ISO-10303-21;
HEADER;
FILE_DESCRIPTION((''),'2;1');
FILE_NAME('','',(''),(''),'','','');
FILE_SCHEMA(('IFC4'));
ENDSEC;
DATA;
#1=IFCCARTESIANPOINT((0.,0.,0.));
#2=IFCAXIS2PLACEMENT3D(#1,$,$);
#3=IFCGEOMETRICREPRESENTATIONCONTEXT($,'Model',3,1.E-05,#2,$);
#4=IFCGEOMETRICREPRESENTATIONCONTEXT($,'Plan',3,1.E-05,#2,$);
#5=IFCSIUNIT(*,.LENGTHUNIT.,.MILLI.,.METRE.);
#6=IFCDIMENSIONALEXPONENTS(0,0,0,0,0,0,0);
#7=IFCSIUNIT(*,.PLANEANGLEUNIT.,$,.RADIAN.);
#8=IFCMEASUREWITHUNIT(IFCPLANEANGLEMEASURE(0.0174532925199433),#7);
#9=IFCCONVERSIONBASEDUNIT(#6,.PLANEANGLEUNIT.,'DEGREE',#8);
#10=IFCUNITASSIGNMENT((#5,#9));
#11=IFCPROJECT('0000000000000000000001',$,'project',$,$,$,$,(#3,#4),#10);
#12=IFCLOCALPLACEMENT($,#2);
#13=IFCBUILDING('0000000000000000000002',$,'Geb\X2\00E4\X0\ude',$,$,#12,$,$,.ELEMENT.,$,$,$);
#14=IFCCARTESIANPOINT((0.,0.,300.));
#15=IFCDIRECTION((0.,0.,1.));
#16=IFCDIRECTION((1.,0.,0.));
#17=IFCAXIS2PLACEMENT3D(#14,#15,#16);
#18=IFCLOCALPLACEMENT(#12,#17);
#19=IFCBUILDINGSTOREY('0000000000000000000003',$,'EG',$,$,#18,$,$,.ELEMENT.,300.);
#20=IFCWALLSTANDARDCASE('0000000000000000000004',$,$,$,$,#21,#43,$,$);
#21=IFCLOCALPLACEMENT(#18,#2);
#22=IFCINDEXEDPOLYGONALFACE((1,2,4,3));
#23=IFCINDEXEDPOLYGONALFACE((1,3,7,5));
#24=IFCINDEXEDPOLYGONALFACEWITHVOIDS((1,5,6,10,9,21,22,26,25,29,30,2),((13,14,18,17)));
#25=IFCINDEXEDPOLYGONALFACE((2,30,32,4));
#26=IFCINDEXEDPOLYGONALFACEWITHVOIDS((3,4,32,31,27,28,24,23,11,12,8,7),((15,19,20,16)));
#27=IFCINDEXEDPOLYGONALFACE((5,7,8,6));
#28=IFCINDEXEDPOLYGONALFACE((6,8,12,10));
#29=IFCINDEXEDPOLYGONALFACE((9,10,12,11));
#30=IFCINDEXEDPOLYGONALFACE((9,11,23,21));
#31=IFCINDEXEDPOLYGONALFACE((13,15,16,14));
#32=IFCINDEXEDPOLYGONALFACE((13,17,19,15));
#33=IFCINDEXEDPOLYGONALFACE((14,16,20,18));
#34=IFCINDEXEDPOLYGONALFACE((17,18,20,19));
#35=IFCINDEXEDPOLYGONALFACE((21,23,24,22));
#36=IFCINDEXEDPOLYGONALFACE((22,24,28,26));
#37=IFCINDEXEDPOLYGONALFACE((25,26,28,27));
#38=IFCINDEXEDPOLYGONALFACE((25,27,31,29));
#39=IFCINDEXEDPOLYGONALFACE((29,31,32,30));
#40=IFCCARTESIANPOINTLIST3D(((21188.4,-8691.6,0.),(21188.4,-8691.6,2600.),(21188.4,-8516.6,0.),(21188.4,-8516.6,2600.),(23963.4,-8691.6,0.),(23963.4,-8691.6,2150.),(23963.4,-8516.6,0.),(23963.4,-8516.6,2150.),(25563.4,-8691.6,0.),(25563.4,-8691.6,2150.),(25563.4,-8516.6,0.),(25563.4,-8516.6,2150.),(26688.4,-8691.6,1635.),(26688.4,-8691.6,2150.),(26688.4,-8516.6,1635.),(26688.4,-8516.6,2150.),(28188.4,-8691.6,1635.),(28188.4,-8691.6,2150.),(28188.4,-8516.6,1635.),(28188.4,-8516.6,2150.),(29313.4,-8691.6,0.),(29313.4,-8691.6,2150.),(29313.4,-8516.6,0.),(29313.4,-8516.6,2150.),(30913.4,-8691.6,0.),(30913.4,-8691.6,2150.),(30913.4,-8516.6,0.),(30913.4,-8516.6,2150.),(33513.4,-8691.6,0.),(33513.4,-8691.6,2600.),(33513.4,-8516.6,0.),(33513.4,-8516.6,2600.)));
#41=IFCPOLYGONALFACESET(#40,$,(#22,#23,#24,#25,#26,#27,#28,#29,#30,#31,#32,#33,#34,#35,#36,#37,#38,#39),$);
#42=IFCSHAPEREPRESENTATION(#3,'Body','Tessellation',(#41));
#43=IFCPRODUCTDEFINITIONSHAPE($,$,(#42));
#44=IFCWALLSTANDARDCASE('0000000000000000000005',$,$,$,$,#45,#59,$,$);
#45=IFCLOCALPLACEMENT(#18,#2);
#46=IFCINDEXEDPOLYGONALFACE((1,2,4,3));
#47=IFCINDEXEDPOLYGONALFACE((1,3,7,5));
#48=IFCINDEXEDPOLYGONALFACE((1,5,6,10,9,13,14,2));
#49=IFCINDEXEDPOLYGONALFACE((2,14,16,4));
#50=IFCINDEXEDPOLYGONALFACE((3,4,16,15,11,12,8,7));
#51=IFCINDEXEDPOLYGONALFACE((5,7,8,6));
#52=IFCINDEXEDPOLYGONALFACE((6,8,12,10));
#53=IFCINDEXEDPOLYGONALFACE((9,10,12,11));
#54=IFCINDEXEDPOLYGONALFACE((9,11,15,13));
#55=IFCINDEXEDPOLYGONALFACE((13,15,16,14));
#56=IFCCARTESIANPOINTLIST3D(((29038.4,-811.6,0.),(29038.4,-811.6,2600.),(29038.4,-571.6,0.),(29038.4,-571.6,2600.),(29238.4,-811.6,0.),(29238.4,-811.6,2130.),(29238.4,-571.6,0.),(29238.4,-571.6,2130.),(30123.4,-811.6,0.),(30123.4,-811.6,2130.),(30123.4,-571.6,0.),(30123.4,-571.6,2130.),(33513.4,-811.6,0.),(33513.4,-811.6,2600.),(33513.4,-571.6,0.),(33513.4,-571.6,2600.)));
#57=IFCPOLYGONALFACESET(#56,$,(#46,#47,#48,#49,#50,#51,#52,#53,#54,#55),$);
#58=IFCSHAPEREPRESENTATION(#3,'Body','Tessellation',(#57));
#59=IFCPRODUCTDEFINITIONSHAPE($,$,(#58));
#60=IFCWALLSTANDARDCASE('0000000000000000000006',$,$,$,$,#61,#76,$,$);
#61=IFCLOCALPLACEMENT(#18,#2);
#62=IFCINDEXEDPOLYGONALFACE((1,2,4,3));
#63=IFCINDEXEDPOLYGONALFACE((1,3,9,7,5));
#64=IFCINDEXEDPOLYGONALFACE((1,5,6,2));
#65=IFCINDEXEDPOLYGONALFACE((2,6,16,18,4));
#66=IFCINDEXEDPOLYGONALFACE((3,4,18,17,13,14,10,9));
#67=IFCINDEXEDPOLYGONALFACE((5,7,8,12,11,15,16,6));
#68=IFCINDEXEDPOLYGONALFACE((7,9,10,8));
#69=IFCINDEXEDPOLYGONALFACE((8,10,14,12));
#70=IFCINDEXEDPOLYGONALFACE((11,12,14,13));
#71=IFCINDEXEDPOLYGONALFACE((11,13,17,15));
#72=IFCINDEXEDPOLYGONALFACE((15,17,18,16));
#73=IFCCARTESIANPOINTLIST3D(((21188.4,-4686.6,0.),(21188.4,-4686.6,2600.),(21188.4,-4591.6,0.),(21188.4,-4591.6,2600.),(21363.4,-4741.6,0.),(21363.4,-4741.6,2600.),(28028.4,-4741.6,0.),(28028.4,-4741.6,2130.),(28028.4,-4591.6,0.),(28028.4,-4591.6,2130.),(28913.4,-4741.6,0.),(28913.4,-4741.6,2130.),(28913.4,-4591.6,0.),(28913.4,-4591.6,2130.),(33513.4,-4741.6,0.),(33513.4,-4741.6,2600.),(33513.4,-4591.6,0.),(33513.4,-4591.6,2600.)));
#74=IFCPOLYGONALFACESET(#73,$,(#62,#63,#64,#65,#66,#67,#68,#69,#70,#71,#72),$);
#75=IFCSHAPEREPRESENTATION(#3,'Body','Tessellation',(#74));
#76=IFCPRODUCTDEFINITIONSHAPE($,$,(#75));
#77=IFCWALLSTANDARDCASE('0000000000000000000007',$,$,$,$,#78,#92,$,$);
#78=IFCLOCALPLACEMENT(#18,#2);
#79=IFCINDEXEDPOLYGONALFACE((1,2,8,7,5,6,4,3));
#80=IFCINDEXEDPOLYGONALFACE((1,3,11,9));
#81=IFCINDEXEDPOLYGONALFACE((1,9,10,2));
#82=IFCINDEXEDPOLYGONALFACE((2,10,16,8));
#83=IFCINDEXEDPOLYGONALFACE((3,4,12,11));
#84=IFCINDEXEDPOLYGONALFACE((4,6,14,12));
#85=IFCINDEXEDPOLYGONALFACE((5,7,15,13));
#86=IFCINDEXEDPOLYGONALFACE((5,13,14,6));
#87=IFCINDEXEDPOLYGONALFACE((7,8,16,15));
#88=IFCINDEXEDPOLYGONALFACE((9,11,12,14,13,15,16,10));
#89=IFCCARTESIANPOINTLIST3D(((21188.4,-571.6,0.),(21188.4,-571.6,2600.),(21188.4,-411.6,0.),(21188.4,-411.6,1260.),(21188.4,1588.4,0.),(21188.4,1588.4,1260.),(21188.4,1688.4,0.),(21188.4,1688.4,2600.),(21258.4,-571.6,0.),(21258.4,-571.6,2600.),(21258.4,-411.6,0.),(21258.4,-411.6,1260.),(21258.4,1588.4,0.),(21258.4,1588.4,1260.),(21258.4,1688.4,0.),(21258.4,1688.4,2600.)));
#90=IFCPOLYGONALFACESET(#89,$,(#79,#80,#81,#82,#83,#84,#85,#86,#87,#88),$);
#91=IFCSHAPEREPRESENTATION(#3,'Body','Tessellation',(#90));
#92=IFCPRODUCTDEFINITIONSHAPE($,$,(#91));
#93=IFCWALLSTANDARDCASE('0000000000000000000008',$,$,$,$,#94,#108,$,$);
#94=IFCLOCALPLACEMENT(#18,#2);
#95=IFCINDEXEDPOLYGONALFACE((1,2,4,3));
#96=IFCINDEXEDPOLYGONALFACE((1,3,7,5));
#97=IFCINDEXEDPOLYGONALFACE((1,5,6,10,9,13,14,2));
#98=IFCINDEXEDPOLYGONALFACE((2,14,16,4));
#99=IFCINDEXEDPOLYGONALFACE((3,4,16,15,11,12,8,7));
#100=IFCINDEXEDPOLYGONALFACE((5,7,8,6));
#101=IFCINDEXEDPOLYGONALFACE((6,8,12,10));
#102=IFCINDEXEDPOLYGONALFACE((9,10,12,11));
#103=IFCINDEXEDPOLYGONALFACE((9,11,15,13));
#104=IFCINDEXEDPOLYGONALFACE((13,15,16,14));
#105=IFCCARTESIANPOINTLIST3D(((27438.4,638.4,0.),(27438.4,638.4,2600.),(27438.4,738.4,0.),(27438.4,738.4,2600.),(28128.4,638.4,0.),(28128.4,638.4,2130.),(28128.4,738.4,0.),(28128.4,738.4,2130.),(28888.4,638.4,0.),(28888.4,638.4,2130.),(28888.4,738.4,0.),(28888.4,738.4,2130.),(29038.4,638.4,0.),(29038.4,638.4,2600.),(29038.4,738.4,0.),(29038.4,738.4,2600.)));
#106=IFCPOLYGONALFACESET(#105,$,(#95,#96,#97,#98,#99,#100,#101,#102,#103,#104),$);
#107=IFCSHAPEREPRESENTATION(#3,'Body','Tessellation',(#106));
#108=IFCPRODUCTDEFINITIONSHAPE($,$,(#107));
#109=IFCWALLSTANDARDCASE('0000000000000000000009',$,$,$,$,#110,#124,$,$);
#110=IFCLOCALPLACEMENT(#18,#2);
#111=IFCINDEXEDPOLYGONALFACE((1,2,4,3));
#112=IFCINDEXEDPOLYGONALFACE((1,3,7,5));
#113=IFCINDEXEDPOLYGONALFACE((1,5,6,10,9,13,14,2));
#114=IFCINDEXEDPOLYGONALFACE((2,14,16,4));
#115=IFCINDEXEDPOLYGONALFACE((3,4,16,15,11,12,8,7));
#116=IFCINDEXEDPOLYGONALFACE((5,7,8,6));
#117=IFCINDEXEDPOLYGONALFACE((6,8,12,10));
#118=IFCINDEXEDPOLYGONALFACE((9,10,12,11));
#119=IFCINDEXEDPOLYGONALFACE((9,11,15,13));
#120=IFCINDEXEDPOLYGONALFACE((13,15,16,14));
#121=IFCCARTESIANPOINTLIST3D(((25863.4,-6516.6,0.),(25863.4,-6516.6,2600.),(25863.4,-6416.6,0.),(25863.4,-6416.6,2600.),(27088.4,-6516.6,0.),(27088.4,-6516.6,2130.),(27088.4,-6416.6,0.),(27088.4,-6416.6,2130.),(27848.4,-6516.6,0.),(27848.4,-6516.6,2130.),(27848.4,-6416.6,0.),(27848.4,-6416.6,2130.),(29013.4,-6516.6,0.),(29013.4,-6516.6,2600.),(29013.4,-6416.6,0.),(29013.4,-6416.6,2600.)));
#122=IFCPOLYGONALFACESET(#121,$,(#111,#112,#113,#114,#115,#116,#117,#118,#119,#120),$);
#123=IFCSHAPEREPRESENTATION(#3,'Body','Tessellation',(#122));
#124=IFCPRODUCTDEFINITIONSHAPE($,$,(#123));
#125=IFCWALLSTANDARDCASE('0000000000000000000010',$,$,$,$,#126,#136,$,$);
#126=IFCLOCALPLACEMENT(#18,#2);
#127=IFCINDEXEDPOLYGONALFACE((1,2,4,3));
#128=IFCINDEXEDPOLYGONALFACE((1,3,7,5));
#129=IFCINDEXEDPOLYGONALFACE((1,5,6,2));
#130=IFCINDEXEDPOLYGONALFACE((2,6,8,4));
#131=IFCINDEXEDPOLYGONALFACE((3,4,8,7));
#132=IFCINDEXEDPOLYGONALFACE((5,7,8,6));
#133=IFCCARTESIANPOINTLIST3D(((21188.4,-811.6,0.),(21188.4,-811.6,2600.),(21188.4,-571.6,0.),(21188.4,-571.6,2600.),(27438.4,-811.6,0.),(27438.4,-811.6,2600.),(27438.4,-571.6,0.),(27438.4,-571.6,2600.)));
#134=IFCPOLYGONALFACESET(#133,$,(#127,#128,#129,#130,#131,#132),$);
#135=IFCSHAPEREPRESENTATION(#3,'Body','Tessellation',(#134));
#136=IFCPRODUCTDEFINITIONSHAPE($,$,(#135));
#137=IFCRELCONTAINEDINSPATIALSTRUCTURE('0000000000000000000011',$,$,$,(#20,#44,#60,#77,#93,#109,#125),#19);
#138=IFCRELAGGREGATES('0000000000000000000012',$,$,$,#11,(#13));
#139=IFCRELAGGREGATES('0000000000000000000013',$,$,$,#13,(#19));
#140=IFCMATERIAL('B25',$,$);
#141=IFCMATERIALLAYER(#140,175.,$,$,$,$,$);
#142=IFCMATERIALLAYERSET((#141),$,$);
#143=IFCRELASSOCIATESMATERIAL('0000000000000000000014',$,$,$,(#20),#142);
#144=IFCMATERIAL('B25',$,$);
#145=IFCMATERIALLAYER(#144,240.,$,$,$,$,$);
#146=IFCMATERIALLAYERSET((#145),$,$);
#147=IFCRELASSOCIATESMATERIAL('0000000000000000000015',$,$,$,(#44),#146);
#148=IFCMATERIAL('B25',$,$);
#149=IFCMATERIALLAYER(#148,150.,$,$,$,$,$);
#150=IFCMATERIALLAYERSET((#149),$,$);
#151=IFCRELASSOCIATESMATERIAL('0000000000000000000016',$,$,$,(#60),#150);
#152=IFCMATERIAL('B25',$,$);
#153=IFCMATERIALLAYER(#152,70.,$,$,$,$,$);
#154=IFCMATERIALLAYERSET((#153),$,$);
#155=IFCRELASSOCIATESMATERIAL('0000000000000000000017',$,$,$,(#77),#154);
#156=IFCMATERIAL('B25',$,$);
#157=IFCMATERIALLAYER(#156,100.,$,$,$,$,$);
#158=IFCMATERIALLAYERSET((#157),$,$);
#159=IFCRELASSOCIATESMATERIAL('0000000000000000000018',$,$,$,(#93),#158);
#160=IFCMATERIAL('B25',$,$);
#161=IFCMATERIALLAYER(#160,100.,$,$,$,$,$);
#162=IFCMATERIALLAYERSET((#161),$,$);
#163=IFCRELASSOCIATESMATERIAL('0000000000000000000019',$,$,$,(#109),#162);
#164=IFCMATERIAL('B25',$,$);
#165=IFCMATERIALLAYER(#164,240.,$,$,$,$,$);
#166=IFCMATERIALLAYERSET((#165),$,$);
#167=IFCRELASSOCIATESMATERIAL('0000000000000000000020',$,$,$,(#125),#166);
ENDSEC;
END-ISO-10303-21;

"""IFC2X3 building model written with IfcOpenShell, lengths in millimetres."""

from ifc_helpers import new_model, entity, si_unit, converted_unit, frame, frame_2d, origin, origin_with_axes, place, context, project, spatial, polyline, rectangle, outline, extrude, material, layer, layer_set, layer_usage, element, save


model = new_model("IFC2X3")

# Units and contexts
model_context = context("Model", 3, precision=1e-05, world=origin())
plan_context = context("Plan", 3, precision=1e-05, world=origin())
ifc_project = project(units=[si_unit("LENGTHUNIT", "METRE", prefix="MILLI"), converted_unit("PLANEANGLEUNIT", "DEGREE", entity("IfcPlaneAngleMeasure", 0.0174532925199433), si_unit("PLANEANGLEUNIT", "RADIAN"), dimensions=[0, 0, 0, 0, 0, 0, 0])], contexts=[model_context, plan_context])

# Building, storey
building_placement = place(None, origin())
building = spatial("IfcBuilding", under=ifc_project, at=building_placement, Name="Gebäude", CompositionType="ELEMENT")
storey_placement = place(building_placement, frame((0.0, 0.0, 300.0), z_axis=(0.0, 0.0, 1.0), x_axis=(1.0, 0.0, 0.0)))
storey = spatial("IfcBuildingStorey", under=building, at=storey_placement, Name="EG", CompositionType="ELEMENT", Elevation=300.0)

# Wall, openings
ifc_material_1 = material(Name="B25")
ifc_layer_1 = layer(ifc_material_1, 175.0)
ifc_layer_set_1 = layer_set([ifc_layer_1])
ifc_layer_usage_1 = layer_usage(ifc_layer_set_1, "AXIS2", "POSITIVE", 0.0)
wall_1_placement = place(storey_placement, frame((21188.4, -8691.6, 0.0), z_axis=(0.0, 0.0, 1.0), x_axis=(1.0, 0.0, 0.0)))
wall_1 = element("IfcWallStandardCase", 1, at=wall_1_placement, inside=storey, material=ifc_layer_usage_1, context=model_context, shape_type="SweptSolid", body=[
    extrude(rectangle(XDim=12325.0, YDim=175.0, at=frame_2d((6162.5, 87.5), x_axis=(1.0, 0.0))), origin_with_axes(), (0.0, 0.0, 1.0), 2600.0),
])
opening_1_placement = place(wall_1_placement, frame((5500.0, 0.0, 1635.0), z_axis=(0.0, 1.0, 0.0), x_axis=(0.0, 0.0, 1.0)))
element("IfcOpeningElement", 2, at=opening_1_placement, cuts=wall_1, ObjectType="Opening", context=model_context, shape_type="SweptSolid", body=[
    extrude(rectangle(XDim=515.0, YDim=1500.0, at=frame_2d((257.5, 750.0), x_axis=(1.0, 0.0))), origin_with_axes(), (0.0, 0.0, 1.0), 175.0),
])
opening_2_placement = place(wall_1_placement, frame((8125.0, 0.0, 0.0), z_axis=(0.0, 1.0, 0.0), x_axis=(0.0, 0.0, 1.0)))
element("IfcOpeningElement", 3, at=opening_2_placement, cuts=wall_1, ObjectType="Opening", context=model_context, shape_type="SweptSolid", body=[
    extrude(rectangle(XDim=2150.0, YDim=1600.0, at=frame_2d((1075.0, 800.0), x_axis=(1.0, 0.0))), origin_with_axes(), (0.0, 0.0, 1.0), 175.0),
])
opening_3_placement = place(wall_1_placement, frame((2775.0, 0.0, 0.0), z_axis=(0.0, 1.0, 0.0), x_axis=(0.0, 0.0, 1.0)))
element("IfcOpeningElement", 4, at=opening_3_placement, cuts=wall_1, ObjectType="Opening", context=model_context, shape_type="SweptSolid", body=[
    extrude(rectangle(XDim=2150.0, YDim=1600.0, at=frame_2d((1075.0, 800.0), x_axis=(1.0, 0.0))), origin_with_axes(), (0.0, 0.0, 1.0), 175.0),
])

# Walls, openings
ifc_material_2 = material(Name="B25")
ifc_layer_2 = layer(ifc_material_2, 240.0)
ifc_layer_set_2 = layer_set([ifc_layer_2])
ifc_layer_usage_2 = layer_usage(ifc_layer_set_2, "AXIS2", "POSITIVE", 0.0)
wall_2_placement = place(storey_placement, frame((33513.4, -571.6, 0.0), z_axis=(0.0, 0.0, 1.0), x_axis=(-1.0, 0.0, 0.0)))
wall_2 = element("IfcWallStandardCase", 5, at=wall_2_placement, inside=storey, material=ifc_layer_usage_2, context=model_context, shape_type="SweptSolid", body=[
    extrude(rectangle(XDim=4475.0, YDim=240.0, at=frame_2d((2237.5, 120.0), x_axis=(1.0, 0.0))), origin_with_axes(), (0.0, 0.0, 1.0), 2600.0),
])
opening_4_placement = place(wall_2_placement, frame((3390.0, 0.0, 0.0), z_axis=(0.0, 1.0, 0.0), x_axis=(0.0, 0.0, 1.0)))
element("IfcOpeningElement", 6, at=opening_4_placement, cuts=wall_2, ObjectType="Opening", context=model_context, shape_type="SweptSolid", body=[
    extrude(rectangle(XDim=2130.0, YDim=885.0, at=frame_2d((1065.0, 442.5), x_axis=(1.0, 0.0))), origin_with_axes(), (0.0, 0.0, 1.0), 240.0),
])
ifc_material_3 = material(Name="B25")
ifc_layer_3 = layer(ifc_material_3, 150.0)
ifc_layer_set_3 = layer_set([ifc_layer_3])
ifc_layer_usage_3 = layer_usage(ifc_layer_set_3, "AXIS2", "POSITIVE", 0.0)
wall_3_placement = place(storey_placement, frame((21363.4, -4741.6, 0.0), z_axis=(0.0, 0.0, 1.0), x_axis=(1.0, 0.0, 0.0)))
wall_3 = element("IfcWallStandardCase", 7, at=wall_3_placement, inside=storey, material=ifc_layer_usage_3, context=model_context, shape_type="SweptSolid", body=[
    extrude(outline(polyline([(0.0, 0.0), (12150.0, 0.0), (12150.0, 150.0), (-175.0, 150.0), (-175.0, 55.0), (0.0, 0.0)])), origin_with_axes(), (0.0, 0.0, 1.0), 2600.0),
])
opening_5_placement = place(wall_3_placement, frame((6665.0, 0.0, 0.0), z_axis=(0.0, 1.0, 0.0), x_axis=(0.0, 0.0, 1.0)))
element("IfcOpeningElement", 8, at=opening_5_placement, cuts=wall_3, ObjectType="Opening", context=model_context, shape_type="SweptSolid", body=[
    extrude(rectangle(XDim=2130.0, YDim=885.0, at=frame_2d((1065.0, 442.5), x_axis=(1.0, 0.0))), origin_with_axes(), (0.0, 0.0, 1.0), 150.0),
])
ifc_material_4 = material(Name="B25")
ifc_layer_4 = layer(ifc_material_4, 70.0)
ifc_layer_set_4 = layer_set([ifc_layer_4])
ifc_layer_usage_4 = layer_usage(ifc_layer_set_4, "AXIS2", "POSITIVE", 0.0)
wall_4_placement = place(storey_placement, frame((21258.4, -571.6, 0.0), z_axis=(0.0, 0.0, 1.0), x_axis=(0.0, 1.0, 0.0)))
wall_4 = element("IfcWallStandardCase", 9, at=wall_4_placement, inside=storey, material=ifc_layer_usage_4, context=model_context, shape_type="SweptSolid", body=[
    extrude(rectangle(XDim=2260.0, YDim=70.0, at=frame_2d((1130.0, 35.0), x_axis=(1.0, 0.0))), origin_with_axes(), (0.0, 0.0, 1.0), 2600.0),
])
opening_6_placement = place(wall_4_placement, frame((160.0, 0.0, -1000.0), z_axis=(0.0, 1.0, 0.0), x_axis=(0.0, 0.0, 1.0)))
element("IfcOpeningElement", 10, at=opening_6_placement, cuts=wall_4, ObjectType="Opening", context=model_context, shape_type="SweptSolid", body=[
    extrude(rectangle(XDim=2260.0, YDim=2000.0, at=frame_2d((1130.0, 1000.0), x_axis=(1.0, 0.0))), origin_with_axes(), (0.0, 0.0, 1.0), 70.0),
])
ifc_material_5 = material(Name="B25")
ifc_layer_5 = layer(ifc_material_5, 100.0)
ifc_layer_set_5 = layer_set([ifc_layer_5])
ifc_layer_usage_5 = layer_usage(ifc_layer_set_5, "AXIS2", "POSITIVE", 0.0)
wall_5_placement = place(storey_placement, frame((29038.4, 738.4, 0.0), z_axis=(0.0, 0.0, 1.0), x_axis=(-1.0, 0.0, 0.0)))
wall_5 = element("IfcWallStandardCase", 11, at=wall_5_placement, inside=storey, material=ifc_layer_usage_5, context=model_context, shape_type="SweptSolid", body=[
    extrude(rectangle(XDim=1600.0, YDim=100.0, at=frame_2d((800.0, 50.0), x_axis=(1.0, 0.0))), origin_with_axes(), (0.0, 0.0, 1.0), 2600.0),
])
opening_7_placement = place(wall_5_placement, frame((150.0, 0.0, 0.0), z_axis=(0.0, 1.0, 0.0), x_axis=(0.0, 0.0, 1.0)))
element("IfcOpeningElement", 12, at=opening_7_placement, cuts=wall_5, ObjectType="Opening", context=model_context, shape_type="SweptSolid", body=[
    extrude(rectangle(XDim=2130.0, YDim=760.0, at=frame_2d((1065.0, 380.0), x_axis=(1.0, 0.0))), origin_with_axes(), (0.0, 0.0, 1.0), 100.0),
])
ifc_material_6 = material(Name="B25")
ifc_layer_6 = layer(ifc_material_6, 100.0)
ifc_layer_set_6 = layer_set([ifc_layer_6])
ifc_layer_usage_6 = layer_usage(ifc_layer_set_6, "AXIS2", "POSITIVE", 0.0)
wall_6_placement = place(storey_placement, frame((25863.4, -6516.6, 0.0), z_axis=(0.0, 0.0, 1.0), x_axis=(1.0, 0.0, 0.0)))
wall_6 = element("IfcWallStandardCase", 13, at=wall_6_placement, inside=storey, material=ifc_layer_usage_6, context=model_context, shape_type="SweptSolid", body=[
    extrude(rectangle(XDim=3150.0, YDim=100.0, at=frame_2d((1575.0, 50.0), x_axis=(1.0, 0.0))), origin_with_axes(), (0.0, 0.0, 1.0), 2600.0),
])
opening_8_placement = place(wall_6_placement, frame((1225.0, 0.0, 0.0), z_axis=(0.0, 1.0, 0.0), x_axis=(0.0, 0.0, 1.0)))
element("IfcOpeningElement", 14, at=opening_8_placement, cuts=wall_6, ObjectType="Opening", context=model_context, shape_type="SweptSolid", body=[
    extrude(rectangle(XDim=2130.0, YDim=760.0, at=frame_2d((1065.0, 380.0), x_axis=(1.0, 0.0))), origin_with_axes(), (0.0, 0.0, 1.0), 100.0),
])

# Wall
ifc_material_7 = material(Name="B25")
ifc_layer_7 = layer(ifc_material_7, 240.0)
ifc_layer_set_7 = layer_set([ifc_layer_7])
ifc_layer_usage_7 = layer_usage(ifc_layer_set_7, "AXIS2", "POSITIVE", 0.0)
wall_7_placement = place(storey_placement, frame((27438.4, -571.6, 0.0), z_axis=(0.0, 0.0, 1.0), x_axis=(-1.0, 0.0, 0.0)))
element("IfcWallStandardCase", 15, at=wall_7_placement, inside=storey, material=ifc_layer_usage_7, context=model_context, shape_type="SweptSolid", body=[
    extrude(rectangle(XDim=6250.0, YDim=240.0, at=frame_2d((3125.0, 120.0), x_axis=(1.0, 0.0))), origin_with_axes(), (0.0, 0.0, 1.0), 2600.0),
])

save(model, "model.ifc")
